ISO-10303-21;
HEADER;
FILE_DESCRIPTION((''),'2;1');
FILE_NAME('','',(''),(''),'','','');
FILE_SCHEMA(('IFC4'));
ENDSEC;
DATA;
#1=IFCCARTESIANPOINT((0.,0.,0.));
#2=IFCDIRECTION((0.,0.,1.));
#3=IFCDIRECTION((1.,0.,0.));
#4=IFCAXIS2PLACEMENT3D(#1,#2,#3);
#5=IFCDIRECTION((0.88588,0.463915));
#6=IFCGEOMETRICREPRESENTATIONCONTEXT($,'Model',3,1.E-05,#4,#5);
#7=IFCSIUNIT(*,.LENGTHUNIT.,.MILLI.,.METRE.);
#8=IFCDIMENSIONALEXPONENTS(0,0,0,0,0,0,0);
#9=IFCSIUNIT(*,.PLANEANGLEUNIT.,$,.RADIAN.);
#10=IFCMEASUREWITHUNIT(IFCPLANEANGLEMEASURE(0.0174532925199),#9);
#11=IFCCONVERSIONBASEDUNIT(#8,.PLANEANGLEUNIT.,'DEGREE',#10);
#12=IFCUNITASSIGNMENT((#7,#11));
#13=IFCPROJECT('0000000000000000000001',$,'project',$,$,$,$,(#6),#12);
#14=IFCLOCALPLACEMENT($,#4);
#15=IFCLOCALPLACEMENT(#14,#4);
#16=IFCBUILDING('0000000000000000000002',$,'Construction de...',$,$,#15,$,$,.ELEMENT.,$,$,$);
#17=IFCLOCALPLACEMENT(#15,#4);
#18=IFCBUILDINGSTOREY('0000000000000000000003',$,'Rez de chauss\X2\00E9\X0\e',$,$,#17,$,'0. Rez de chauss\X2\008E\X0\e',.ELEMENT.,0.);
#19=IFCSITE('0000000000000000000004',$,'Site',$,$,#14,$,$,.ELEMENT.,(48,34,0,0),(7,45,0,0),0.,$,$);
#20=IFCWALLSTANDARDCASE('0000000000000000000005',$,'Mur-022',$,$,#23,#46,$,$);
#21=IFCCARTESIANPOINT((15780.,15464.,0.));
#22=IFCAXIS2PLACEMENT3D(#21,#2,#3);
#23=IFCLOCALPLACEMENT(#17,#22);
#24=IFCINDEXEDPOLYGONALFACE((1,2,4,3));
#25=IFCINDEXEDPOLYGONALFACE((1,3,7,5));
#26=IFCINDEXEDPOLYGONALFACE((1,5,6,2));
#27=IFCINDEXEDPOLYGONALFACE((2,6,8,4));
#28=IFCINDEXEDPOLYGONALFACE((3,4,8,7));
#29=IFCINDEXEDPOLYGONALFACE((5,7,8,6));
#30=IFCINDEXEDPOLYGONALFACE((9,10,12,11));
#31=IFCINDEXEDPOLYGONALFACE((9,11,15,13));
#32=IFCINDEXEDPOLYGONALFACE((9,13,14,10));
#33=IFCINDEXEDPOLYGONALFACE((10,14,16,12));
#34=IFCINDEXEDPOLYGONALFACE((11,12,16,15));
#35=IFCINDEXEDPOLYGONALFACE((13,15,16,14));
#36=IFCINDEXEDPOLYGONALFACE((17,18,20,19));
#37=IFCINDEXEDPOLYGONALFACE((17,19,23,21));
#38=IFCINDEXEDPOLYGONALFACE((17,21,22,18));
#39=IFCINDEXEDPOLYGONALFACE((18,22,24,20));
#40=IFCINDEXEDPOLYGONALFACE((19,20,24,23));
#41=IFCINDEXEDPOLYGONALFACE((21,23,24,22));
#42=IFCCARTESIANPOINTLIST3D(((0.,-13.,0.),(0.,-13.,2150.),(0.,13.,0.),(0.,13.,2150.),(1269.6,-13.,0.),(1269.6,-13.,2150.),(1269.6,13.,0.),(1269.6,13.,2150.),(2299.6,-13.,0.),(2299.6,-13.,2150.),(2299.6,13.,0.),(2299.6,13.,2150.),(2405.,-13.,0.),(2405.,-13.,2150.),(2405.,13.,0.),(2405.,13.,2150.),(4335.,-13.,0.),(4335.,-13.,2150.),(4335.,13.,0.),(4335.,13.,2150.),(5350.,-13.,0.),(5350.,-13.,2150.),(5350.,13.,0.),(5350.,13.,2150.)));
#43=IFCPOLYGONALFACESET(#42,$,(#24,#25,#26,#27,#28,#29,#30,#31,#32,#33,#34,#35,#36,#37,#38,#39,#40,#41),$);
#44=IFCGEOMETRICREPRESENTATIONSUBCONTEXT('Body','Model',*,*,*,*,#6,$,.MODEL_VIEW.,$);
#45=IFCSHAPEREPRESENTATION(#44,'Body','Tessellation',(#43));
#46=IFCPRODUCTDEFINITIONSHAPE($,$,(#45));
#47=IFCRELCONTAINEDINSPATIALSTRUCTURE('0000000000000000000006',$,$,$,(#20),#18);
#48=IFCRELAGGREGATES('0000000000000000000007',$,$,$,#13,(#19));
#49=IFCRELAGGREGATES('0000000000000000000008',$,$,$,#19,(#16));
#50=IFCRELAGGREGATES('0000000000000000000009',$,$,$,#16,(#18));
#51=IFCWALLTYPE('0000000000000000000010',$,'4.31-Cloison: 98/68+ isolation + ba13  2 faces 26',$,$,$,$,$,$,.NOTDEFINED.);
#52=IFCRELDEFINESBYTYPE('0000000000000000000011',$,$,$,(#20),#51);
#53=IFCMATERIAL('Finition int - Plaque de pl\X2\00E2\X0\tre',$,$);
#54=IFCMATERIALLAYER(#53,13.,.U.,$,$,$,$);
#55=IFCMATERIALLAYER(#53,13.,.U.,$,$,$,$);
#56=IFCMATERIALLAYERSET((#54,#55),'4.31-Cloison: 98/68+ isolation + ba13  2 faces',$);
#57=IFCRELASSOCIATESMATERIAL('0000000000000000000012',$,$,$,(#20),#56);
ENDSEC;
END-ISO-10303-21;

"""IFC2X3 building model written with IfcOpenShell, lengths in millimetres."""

from ifc_helpers import new_model, entity, si_unit, converted_unit, direction, frame, origin_with_axes, origin_2d_with_axis, place, context, subcontext, project, spatial, polyline, rectangle, outline, extrude, material, layer, layer_set, layer_usage, type_object, element, save


model = new_model("IFC2X3")

# Units and contexts
model_context = context("Model", 3, precision=1e-05, world=origin_with_axes(), true_north=direction((0.88588, 0.463915)))
body_context = subcontext(model_context, "Body", "Model", "MODEL_VIEW")
ifc_project = project(units=[si_unit("LENGTHUNIT", "METRE", prefix="MILLI"), converted_unit("PLANEANGLEUNIT", "DEGREE", entity("IfcPlaneAngleMeasure", 0.0174532925199), si_unit("PLANEANGLEUNIT", "RADIAN"), dimensions=[0, 0, 0, 0, 0, 0, 0])], contexts=[model_context])

# Site, building, storey
site_placement = place(None, origin_with_axes())
site = spatial("IfcSite", under=ifc_project, at=site_placement, Name="Site", CompositionType="ELEMENT", RefLatitude=(48, 34, 0, 0), RefLongitude=(7, 45, 0, 0), RefElevation=0.0)
building_placement = place(site_placement, origin_with_axes())
building = spatial("IfcBuilding", under=site, at=building_placement, Name="Construction de...", CompositionType="ELEMENT")
storey_placement = place(building_placement, origin_with_axes())
storey = spatial("IfcBuildingStorey", under=building, at=storey_placement, Name="Rez de chaussée", LongName="0. Rez de chauss\u008ee", CompositionType="ELEMENT", Elevation=0.0)

# Shared definitions
ifc_material_1 = material(Name="Finition int - Plaque de plâtre")
ifc_layer_1 = layer(ifc_material_1, 13.0, ventilated="UNKNOWN")
ifc_layer_2 = layer(ifc_material_1, 13.0, ventilated="UNKNOWN")
ifc_layer_set_1 = layer_set([ifc_layer_1, ifc_layer_2], Name="4.31-Cloison: 98/68+ isolation + ba13  2 faces")
wall_type_1 = type_object("IfcWallType", Name="4.31-Cloison: 98/68+ isolation + ba13  2 faces 26", PredefinedType="NOTDEFINED")

# Wall, openings
ifc_layer_usage_1 = layer_usage(ifc_layer_set_1, "AXIS2", "NEGATIVE", 13.0)
wall_1_placement = place(storey_placement, frame((15780.0, 15464.0, 0.0), z_axis=(0.0, 0.0, 1.0), x_axis=(1.0, 0.0, 0.0)))
wall_1 = element("IfcWallStandardCase", 1, at=wall_1_placement, inside=storey, type_object=wall_type_1, material=ifc_layer_usage_1, Name="Mur-022", context=body_context, shape_type="SweptSolid", body=[
    extrude(outline(polyline([(0.0, -13.0), (5350.0, -13.0), (5350.0, 13.0), (0.0, 13.0), (0.0, -13.0)])), origin_with_axes(), (0.0, 0.0, 1.0), 2150.0),
])
opening_1_placement = place(wall_1_placement, frame((1784.6, 0.0, 0.0), z_axis=(0.0, 0.0, 1.0), x_axis=(1.0, 0.0, 0.0)))
element("IfcOpeningElement", 2, at=opening_1_placement, cuts=wall_1, context=body_context, shape_type="SweptSolid", body=[
    extrude(rectangle(XDim=1030.0, YDim=2150.0, at=origin_2d_with_axis()), frame((0.0, 26.0, 1075.0), z_axis=(0.0, 1.0, 0.0), x_axis=(1.0, 0.0, 0.0)), (0.0, 0.0, -1.0), 78.0),
])
opening_2_placement = place(wall_1_placement, frame((3370.0, 0.0, 0.0), z_axis=(0.0, 0.0, 1.0), x_axis=(1.0, 0.0, 0.0)))
element("IfcOpeningElement", 3, at=opening_2_placement, cuts=wall_1, context=body_context, shape_type="SweptSolid", body=[
    extrude(rectangle(XDim=1930.0, YDim=2165.0, at=origin_2d_with_axis()), frame((0.0, -26.0, 1082.5), z_axis=(0.0, -1.0, 0.0), x_axis=(-1.0, 0.0, 0.0)), (0.0, 0.0, -1.0), 78.0),
])

save(model, "model.ifc")
